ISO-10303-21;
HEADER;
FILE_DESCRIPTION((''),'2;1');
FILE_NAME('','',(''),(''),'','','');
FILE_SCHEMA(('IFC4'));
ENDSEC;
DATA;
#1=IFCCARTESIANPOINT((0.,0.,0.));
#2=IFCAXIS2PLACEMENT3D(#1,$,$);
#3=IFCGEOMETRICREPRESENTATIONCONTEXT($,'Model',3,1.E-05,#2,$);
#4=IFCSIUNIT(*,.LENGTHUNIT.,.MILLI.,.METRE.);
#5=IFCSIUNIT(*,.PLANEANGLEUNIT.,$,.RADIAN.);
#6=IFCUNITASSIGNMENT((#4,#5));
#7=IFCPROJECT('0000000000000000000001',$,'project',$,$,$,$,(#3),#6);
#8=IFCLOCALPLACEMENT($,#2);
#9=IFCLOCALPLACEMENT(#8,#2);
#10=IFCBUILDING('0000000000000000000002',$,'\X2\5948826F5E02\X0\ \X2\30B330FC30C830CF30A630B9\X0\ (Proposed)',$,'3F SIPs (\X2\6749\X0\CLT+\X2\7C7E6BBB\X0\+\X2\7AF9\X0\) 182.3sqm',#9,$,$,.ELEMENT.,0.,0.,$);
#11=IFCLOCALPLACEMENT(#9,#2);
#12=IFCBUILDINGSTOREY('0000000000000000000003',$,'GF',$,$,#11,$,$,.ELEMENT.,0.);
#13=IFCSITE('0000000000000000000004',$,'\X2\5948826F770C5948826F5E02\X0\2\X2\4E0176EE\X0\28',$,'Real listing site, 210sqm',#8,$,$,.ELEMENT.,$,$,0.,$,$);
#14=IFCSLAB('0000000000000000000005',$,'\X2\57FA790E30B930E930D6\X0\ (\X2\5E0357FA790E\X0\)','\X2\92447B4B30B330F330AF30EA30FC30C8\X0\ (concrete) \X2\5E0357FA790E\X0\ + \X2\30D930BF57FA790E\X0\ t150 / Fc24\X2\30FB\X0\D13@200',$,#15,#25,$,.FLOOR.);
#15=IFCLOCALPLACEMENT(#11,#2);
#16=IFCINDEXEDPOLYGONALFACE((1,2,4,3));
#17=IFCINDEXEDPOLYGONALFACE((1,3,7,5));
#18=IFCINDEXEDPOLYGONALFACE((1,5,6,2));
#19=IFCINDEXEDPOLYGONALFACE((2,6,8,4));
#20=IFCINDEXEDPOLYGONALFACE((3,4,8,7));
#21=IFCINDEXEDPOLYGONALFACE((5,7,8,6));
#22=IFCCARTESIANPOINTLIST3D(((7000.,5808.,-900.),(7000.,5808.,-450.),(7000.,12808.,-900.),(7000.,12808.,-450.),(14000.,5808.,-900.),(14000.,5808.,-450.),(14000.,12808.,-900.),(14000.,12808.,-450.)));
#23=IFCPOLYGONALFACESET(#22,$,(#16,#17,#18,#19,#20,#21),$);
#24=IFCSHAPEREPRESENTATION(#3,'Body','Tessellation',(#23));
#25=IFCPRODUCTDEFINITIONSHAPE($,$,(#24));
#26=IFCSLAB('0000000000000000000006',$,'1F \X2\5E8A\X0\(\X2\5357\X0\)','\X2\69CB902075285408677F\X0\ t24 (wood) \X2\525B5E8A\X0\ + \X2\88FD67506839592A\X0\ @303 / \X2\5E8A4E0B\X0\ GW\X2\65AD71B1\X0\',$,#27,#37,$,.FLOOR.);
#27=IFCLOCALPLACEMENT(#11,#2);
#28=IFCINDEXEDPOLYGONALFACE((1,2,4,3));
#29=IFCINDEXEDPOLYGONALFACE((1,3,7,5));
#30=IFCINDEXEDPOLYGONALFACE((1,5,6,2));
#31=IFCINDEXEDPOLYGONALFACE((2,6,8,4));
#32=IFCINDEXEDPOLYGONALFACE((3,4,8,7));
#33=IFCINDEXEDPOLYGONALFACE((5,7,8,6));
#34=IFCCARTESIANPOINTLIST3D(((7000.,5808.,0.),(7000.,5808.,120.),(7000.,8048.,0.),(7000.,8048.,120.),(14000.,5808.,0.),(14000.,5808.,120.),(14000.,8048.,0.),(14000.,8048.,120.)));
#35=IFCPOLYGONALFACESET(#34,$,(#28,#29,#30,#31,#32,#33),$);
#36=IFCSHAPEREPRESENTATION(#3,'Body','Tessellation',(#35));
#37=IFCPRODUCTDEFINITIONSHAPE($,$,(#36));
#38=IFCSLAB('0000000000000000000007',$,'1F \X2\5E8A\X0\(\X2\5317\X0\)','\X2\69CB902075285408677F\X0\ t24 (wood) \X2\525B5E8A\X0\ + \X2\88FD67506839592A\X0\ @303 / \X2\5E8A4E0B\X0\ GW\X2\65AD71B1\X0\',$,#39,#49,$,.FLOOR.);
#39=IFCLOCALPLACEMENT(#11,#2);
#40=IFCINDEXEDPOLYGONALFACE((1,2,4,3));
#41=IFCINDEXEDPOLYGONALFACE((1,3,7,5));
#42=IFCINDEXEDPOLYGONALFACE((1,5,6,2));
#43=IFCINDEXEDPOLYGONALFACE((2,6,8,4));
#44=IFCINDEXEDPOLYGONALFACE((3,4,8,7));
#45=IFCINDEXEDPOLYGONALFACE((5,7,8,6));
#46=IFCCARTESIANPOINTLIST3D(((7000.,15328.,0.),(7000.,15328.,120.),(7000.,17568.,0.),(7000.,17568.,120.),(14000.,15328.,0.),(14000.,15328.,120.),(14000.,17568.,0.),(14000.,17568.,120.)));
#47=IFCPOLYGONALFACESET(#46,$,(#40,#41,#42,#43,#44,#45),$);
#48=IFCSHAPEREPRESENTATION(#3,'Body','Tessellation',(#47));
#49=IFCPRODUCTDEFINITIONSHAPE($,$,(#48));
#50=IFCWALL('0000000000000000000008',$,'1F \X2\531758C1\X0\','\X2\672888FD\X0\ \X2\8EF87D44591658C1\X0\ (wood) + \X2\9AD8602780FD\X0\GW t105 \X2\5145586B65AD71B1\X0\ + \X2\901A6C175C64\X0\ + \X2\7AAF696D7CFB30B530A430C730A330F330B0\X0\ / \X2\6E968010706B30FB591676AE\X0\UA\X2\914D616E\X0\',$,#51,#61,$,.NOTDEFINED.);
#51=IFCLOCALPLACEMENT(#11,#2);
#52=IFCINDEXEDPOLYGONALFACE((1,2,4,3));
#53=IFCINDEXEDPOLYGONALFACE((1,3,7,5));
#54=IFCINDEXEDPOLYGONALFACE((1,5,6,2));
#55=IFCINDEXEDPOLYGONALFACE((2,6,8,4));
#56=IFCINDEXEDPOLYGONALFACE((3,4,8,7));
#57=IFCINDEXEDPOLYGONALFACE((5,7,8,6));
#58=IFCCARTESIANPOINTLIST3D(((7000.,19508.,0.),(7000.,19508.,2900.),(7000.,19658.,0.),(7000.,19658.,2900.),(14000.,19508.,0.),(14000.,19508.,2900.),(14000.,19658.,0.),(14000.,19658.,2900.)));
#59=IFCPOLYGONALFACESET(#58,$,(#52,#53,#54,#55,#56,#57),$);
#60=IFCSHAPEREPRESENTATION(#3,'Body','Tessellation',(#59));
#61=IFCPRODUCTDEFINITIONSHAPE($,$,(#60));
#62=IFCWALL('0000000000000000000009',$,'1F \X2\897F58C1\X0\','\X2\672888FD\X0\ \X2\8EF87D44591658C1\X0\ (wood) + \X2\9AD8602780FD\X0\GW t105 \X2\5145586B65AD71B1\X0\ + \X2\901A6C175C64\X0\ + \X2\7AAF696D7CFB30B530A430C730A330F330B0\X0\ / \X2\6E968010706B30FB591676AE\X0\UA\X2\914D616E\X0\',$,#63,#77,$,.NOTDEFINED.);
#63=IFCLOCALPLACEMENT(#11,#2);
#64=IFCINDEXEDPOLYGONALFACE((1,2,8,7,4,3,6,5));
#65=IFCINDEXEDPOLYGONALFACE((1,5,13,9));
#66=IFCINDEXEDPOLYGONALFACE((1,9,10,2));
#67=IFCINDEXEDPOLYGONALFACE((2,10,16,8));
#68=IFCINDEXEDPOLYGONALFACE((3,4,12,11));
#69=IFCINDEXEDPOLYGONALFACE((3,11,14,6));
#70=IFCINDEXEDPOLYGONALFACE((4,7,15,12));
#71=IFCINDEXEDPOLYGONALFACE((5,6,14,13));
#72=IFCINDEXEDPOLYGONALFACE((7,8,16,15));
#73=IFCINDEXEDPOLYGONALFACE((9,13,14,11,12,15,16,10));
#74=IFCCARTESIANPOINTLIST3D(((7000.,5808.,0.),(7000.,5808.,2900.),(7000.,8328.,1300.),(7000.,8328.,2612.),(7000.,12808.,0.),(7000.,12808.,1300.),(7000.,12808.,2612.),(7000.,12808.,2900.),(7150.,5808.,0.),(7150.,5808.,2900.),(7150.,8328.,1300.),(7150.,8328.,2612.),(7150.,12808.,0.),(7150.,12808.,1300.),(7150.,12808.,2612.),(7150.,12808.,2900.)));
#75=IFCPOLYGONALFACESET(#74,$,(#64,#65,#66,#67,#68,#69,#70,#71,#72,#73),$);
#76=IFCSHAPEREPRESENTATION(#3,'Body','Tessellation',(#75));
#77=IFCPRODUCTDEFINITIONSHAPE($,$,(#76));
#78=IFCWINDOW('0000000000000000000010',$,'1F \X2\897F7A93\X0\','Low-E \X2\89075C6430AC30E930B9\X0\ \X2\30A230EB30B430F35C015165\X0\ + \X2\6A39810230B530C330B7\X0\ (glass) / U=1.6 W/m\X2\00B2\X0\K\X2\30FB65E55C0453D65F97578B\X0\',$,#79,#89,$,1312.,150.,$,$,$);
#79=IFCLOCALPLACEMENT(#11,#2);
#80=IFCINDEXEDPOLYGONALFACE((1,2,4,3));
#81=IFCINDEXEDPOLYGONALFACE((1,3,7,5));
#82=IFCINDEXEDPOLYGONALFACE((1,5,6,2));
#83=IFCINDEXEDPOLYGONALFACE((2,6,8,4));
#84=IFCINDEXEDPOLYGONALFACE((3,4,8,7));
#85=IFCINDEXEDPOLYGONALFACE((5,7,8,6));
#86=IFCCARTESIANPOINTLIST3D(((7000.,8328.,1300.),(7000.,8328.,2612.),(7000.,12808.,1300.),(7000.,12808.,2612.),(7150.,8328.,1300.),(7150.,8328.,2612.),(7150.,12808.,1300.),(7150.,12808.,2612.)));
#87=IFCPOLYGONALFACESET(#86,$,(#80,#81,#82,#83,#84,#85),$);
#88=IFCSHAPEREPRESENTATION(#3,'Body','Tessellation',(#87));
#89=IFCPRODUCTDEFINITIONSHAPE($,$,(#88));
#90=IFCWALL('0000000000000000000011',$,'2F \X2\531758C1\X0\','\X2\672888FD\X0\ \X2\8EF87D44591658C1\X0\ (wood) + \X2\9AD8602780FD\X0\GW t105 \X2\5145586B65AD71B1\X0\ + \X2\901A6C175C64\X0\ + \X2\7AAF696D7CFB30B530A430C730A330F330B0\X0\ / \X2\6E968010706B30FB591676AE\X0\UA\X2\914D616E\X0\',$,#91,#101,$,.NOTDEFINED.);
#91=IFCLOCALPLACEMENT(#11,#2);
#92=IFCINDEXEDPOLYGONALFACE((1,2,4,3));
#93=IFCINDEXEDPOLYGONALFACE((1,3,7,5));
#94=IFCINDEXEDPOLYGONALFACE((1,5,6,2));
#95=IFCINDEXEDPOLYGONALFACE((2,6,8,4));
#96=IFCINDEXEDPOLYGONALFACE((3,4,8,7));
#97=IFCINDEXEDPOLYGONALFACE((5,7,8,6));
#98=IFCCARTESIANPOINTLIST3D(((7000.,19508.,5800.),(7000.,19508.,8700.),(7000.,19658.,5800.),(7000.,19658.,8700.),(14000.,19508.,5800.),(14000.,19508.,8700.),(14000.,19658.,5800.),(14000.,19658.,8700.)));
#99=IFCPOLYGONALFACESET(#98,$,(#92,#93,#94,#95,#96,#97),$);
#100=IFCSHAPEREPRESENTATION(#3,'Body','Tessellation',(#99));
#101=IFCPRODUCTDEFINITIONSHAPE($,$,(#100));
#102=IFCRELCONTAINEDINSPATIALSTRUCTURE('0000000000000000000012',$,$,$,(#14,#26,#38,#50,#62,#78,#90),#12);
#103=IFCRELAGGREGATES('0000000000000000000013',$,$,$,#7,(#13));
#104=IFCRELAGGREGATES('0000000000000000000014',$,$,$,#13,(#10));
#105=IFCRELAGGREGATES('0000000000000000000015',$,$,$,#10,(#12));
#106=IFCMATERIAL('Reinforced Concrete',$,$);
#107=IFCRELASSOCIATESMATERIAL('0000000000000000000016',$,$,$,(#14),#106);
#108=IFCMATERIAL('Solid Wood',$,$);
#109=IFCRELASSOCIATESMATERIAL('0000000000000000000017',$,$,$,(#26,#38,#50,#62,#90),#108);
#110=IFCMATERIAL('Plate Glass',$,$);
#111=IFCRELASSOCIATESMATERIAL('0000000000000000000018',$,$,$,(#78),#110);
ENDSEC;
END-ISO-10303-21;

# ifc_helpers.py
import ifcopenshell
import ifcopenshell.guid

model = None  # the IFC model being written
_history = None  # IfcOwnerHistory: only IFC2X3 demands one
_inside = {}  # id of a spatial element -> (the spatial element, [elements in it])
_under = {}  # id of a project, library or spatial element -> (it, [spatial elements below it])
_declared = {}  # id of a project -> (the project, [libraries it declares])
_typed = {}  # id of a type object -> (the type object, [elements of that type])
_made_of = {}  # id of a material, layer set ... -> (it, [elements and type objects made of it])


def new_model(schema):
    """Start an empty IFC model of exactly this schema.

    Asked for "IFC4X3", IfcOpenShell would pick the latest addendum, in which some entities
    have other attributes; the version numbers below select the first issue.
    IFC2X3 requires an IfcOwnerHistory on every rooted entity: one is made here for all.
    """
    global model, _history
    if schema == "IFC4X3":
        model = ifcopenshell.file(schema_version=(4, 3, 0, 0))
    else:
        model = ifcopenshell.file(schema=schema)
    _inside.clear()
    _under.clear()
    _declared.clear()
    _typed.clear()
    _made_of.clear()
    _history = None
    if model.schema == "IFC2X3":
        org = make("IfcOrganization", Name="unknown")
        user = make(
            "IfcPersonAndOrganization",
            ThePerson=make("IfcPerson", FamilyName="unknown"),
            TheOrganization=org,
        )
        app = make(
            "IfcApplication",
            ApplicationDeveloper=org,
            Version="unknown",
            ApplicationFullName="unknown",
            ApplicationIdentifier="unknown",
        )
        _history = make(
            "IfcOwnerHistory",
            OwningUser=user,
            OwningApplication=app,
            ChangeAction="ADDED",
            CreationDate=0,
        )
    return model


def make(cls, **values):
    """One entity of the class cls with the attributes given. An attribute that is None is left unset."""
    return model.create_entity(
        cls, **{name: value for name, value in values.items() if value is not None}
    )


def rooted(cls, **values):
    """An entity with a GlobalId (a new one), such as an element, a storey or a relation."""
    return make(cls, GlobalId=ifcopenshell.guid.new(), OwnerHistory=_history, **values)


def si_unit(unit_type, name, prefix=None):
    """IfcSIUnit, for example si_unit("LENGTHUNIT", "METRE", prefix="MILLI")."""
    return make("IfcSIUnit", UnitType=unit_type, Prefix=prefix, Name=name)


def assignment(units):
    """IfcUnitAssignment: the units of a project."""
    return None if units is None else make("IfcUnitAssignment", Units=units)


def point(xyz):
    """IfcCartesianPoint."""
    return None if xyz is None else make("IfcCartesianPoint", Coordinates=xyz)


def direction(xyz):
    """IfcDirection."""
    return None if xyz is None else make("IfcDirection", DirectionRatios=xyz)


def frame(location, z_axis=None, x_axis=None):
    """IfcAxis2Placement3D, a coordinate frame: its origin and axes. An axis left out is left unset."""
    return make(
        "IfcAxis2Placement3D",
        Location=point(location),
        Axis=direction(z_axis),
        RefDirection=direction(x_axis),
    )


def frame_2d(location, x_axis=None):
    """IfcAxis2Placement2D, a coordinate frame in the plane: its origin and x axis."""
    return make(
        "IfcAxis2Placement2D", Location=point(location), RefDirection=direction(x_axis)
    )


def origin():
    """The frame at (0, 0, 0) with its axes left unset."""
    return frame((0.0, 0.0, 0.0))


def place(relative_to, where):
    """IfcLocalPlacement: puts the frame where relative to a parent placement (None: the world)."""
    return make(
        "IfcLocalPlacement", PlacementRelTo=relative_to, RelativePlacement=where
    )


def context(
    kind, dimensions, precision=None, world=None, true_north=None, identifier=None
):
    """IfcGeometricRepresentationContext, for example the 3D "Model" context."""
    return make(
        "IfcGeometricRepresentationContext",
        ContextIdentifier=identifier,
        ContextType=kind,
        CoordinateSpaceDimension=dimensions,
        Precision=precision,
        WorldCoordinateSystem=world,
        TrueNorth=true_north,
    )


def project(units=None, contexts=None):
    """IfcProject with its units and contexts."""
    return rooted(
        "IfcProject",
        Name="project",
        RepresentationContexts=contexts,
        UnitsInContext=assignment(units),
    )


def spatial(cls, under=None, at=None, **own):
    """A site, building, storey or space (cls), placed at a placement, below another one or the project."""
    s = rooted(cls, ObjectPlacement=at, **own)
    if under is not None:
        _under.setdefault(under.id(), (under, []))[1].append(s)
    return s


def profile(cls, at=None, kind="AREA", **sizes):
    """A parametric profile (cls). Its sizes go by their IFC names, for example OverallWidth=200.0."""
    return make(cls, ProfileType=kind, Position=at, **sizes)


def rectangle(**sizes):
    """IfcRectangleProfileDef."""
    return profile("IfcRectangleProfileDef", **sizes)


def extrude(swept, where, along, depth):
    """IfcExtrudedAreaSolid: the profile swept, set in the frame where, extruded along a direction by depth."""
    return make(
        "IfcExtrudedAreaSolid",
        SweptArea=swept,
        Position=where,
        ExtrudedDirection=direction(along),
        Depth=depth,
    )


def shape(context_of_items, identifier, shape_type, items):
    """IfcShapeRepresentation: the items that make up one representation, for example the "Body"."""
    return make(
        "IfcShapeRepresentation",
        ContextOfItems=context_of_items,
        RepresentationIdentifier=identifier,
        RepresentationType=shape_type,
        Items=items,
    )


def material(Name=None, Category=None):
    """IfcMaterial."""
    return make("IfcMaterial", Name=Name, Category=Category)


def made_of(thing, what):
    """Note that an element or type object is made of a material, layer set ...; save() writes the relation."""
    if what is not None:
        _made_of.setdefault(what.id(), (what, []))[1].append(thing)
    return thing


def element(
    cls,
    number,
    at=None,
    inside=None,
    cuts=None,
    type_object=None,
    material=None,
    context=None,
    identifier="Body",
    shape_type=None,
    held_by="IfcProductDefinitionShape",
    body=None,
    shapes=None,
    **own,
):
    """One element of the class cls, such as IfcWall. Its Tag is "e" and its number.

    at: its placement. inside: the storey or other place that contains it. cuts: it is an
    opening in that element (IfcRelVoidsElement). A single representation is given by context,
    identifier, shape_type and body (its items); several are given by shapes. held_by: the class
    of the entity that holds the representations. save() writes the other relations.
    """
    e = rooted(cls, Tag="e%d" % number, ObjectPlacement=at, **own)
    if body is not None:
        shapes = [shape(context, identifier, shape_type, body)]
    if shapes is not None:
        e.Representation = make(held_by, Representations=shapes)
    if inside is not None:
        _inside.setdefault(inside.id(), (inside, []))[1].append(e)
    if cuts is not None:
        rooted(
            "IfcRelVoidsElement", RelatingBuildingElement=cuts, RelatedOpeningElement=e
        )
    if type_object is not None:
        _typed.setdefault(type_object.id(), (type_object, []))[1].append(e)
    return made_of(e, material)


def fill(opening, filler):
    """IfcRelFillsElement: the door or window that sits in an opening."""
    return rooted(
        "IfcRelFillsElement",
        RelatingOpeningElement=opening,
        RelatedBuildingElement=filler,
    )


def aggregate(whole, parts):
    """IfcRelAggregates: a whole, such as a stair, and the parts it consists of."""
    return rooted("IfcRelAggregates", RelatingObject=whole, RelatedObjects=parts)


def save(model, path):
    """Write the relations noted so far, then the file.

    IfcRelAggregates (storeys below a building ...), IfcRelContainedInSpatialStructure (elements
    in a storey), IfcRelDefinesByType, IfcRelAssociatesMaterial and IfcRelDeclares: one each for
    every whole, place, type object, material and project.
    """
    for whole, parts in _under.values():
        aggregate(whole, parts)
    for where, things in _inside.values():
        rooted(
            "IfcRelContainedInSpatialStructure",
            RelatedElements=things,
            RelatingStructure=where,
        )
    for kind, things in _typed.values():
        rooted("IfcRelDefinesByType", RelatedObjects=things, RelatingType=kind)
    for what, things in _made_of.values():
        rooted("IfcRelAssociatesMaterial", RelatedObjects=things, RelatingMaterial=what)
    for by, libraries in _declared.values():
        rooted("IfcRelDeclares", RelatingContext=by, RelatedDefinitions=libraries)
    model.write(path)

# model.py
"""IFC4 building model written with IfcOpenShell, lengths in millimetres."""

from ifc_helpers import new_model, si_unit, frame, frame_2d, origin, place, context, project, spatial, rectangle, extrude, material, element, fill, save


model = new_model("IFC4")

# Units and contexts
model_context = context("Model", 3, precision=1e-05, world=origin())
ifc_project = project(units=[si_unit("LENGTHUNIT", "METRE", prefix="MILLI"), si_unit("PLANEANGLEUNIT", "RADIAN")], contexts=[model_context])

# Site, building, storey
site_placement = place(None, origin())
site = spatial("IfcSite", under=ifc_project, at=site_placement, Name="奈良県奈良市2丁目28", ObjectType="Real listing site, 210sqm", CompositionType="ELEMENT", RefElevation=0.0)
building_placement = place(site_placement, origin())
building = spatial("IfcBuilding", under=site, at=building_placement, Name="奈良市 コートハウス (Proposed)", ObjectType="3F SIPs (杉CLT+籾殻+竹) 182.3sqm", CompositionType="ELEMENT", ElevationOfRefHeight=0.0, ElevationOfTerrain=0.0)
storey_placement = place(building_placement, origin())
storey = spatial("IfcBuildingStorey", under=building, at=storey_placement, Name="GF", CompositionType="ELEMENT", Elevation=0.0)

# Slabs
ifc_material_1 = material(Name="Reinforced Concrete")
slab_1_placement = place(storey_placement, frame((3500.0, 2904.0, -450.0)))
element("IfcSlab", 1, at=slab_1_placement, inside=storey, material=ifc_material_1, Name="基礎スラブ (布基礎)", Description="鉄筋コンクリート (concrete) 布基礎 + ベタ基礎 t150 / Fc24・D13@200", PredefinedType="FLOOR", context=model_context, shape_type="SweptSolid", body=[
    extrude(rectangle(XDim=7000.0, YDim=7000.0, at=frame_2d((3500.0, 3500.0))), frame((3500.0, 2904.0, -450.0)), (0.0, 0.0, 1.0), 450.0),
])
ifc_material_2 = material(Name="Solid Wood")
slab_2_placement = place(storey_placement, frame((3500.0, 2904.0, 0.0)))
element("IfcSlab", 2, at=slab_2_placement, inside=storey, material=ifc_material_2, Name="1F 床(南)", Description="構造用合板 t24 (wood) 剛床 + 製材根太 @303 / 床下 GW断熱", PredefinedType="FLOOR", context=model_context, shape_type="SweptSolid", body=[
    extrude(rectangle(XDim=7000.0, YDim=2240.0, at=frame_2d((3500.0, 1120.0))), frame((3500.0, 2904.0, 0.0)), (0.0, 0.0, 1.0), 120.0),
])
slab_3_placement = place(storey_placement, frame((3500.0, 7664.0, 0.0)))
element("IfcSlab", 3, at=slab_3_placement, inside=storey, material=ifc_material_2, Name="1F 床(北)", Description="構造用合板 t24 (wood) 剛床 + 製材根太 @303 / 床下 GW断熱", PredefinedType="FLOOR", context=model_context, shape_type="SweptSolid", body=[
    extrude(rectangle(XDim=7000.0, YDim=2240.0, at=frame_2d((3500.0, 1120.0))), frame((3500.0, 7664.0, 0.0)), (0.0, 0.0, 1.0), 120.0),
])

# Shared definitions
ifc_material_3 = material(Name="Plate Glass")

# Wall
wall_1_placement = place(storey_placement, frame((3500.0, 9754.0, 0.0)))
element("IfcWall", 4, at=wall_1_placement, inside=storey, material=ifc_material_2, Name="1F 北壁", Description="木製 軸組外壁 (wood) + 高性能GW t105 充填断熱 + 通気層 + 窯業系サイディング / 準耐火・外皮UA配慮", PredefinedType="NOTDEFINED", context=model_context, shape_type="SweptSolid", body=[
    extrude(rectangle(XDim=7000.0, YDim=150.0, at=frame_2d((3500.0, 75.0))), frame((3500.0, 9754.0, 0.0)), (0.0, 0.0, 1.0), 2900.0),
])

# Wall, opening, window
wall_2_placement = place(storey_placement, frame((3500.0, 2904.0, 0.0)))
wall_2 = element("IfcWall", 5, at=wall_2_placement, inside=storey, material=ifc_material_2, Name="1F 西壁", Description="木製 軸組外壁 (wood) + 高性能GW t105 充填断熱 + 通気層 + 窯業系サイディング / 準耐火・外皮UA配慮", PredefinedType="NOTDEFINED", context=model_context, shape_type="SweptSolid", body=[
    extrude(rectangle(XDim=150.0, YDim=7000.0, at=frame_2d((75.0, 3500.0))), frame((3500.0, 2904.0, 0.0)), (0.0, 0.0, 1.0), 2900.0),
])
opening_1_placement = place(storey_placement, frame((3500.0, 4164.0, 650.0)))
opening_1 = element("IfcOpeningElement", 6, at=opening_1_placement, cuts=wall_2, PredefinedType="NOTDEFINED", context=model_context, shape_type="SweptSolid", body=[
    extrude(rectangle(XDim=150.0, YDim=4480.0, at=frame_2d((75.0, 2240.0))), frame((3500.0, 4164.0, 650.0)), (0.0, 0.0, 1.0), 1312.0),
])
window_1_placement = place(storey_placement, frame((3500.0, 4164.0, 650.0)))
window_1 = element("IfcWindow", 7, at=window_1_placement, inside=storey, material=ifc_material_3, Name="1F 西窓", Description="Low-E 複層ガラス アルゴン封入 + 樹脂サッシ (glass) / U=1.6 W/m²K・日射取得型", OverallHeight=1312.0, OverallWidth=150.0, context=model_context, shape_type="SweptSolid", body=[
    extrude(rectangle(XDim=150.0, YDim=4480.0, at=frame_2d((75.0, 2240.0))), frame((3500.0, 4164.0, 650.0)), (0.0, 0.0, 1.0), 1312.0),
])
fill(opening_1, window_1)

# Wall
wall_3_placement = place(storey_placement, frame((3500.0, 9754.0, 2900.0)))
element("IfcWall", 8, at=wall_3_placement, inside=storey, material=ifc_material_2, Name="2F 北壁", Description="木製 軸組外壁 (wood) + 高性能GW t105 充填断熱 + 通気層 + 窯業系サイディング / 準耐火・外皮UA配慮", PredefinedType="NOTDEFINED", context=model_context, shape_type="SweptSolid", body=[
    extrude(rectangle(XDim=7000.0, YDim=150.0, at=frame_2d((3500.0, 75.0))), frame((3500.0, 9754.0, 2900.0)), (0.0, 0.0, 1.0), 2900.0),
])

save(model, "model.ifc")
